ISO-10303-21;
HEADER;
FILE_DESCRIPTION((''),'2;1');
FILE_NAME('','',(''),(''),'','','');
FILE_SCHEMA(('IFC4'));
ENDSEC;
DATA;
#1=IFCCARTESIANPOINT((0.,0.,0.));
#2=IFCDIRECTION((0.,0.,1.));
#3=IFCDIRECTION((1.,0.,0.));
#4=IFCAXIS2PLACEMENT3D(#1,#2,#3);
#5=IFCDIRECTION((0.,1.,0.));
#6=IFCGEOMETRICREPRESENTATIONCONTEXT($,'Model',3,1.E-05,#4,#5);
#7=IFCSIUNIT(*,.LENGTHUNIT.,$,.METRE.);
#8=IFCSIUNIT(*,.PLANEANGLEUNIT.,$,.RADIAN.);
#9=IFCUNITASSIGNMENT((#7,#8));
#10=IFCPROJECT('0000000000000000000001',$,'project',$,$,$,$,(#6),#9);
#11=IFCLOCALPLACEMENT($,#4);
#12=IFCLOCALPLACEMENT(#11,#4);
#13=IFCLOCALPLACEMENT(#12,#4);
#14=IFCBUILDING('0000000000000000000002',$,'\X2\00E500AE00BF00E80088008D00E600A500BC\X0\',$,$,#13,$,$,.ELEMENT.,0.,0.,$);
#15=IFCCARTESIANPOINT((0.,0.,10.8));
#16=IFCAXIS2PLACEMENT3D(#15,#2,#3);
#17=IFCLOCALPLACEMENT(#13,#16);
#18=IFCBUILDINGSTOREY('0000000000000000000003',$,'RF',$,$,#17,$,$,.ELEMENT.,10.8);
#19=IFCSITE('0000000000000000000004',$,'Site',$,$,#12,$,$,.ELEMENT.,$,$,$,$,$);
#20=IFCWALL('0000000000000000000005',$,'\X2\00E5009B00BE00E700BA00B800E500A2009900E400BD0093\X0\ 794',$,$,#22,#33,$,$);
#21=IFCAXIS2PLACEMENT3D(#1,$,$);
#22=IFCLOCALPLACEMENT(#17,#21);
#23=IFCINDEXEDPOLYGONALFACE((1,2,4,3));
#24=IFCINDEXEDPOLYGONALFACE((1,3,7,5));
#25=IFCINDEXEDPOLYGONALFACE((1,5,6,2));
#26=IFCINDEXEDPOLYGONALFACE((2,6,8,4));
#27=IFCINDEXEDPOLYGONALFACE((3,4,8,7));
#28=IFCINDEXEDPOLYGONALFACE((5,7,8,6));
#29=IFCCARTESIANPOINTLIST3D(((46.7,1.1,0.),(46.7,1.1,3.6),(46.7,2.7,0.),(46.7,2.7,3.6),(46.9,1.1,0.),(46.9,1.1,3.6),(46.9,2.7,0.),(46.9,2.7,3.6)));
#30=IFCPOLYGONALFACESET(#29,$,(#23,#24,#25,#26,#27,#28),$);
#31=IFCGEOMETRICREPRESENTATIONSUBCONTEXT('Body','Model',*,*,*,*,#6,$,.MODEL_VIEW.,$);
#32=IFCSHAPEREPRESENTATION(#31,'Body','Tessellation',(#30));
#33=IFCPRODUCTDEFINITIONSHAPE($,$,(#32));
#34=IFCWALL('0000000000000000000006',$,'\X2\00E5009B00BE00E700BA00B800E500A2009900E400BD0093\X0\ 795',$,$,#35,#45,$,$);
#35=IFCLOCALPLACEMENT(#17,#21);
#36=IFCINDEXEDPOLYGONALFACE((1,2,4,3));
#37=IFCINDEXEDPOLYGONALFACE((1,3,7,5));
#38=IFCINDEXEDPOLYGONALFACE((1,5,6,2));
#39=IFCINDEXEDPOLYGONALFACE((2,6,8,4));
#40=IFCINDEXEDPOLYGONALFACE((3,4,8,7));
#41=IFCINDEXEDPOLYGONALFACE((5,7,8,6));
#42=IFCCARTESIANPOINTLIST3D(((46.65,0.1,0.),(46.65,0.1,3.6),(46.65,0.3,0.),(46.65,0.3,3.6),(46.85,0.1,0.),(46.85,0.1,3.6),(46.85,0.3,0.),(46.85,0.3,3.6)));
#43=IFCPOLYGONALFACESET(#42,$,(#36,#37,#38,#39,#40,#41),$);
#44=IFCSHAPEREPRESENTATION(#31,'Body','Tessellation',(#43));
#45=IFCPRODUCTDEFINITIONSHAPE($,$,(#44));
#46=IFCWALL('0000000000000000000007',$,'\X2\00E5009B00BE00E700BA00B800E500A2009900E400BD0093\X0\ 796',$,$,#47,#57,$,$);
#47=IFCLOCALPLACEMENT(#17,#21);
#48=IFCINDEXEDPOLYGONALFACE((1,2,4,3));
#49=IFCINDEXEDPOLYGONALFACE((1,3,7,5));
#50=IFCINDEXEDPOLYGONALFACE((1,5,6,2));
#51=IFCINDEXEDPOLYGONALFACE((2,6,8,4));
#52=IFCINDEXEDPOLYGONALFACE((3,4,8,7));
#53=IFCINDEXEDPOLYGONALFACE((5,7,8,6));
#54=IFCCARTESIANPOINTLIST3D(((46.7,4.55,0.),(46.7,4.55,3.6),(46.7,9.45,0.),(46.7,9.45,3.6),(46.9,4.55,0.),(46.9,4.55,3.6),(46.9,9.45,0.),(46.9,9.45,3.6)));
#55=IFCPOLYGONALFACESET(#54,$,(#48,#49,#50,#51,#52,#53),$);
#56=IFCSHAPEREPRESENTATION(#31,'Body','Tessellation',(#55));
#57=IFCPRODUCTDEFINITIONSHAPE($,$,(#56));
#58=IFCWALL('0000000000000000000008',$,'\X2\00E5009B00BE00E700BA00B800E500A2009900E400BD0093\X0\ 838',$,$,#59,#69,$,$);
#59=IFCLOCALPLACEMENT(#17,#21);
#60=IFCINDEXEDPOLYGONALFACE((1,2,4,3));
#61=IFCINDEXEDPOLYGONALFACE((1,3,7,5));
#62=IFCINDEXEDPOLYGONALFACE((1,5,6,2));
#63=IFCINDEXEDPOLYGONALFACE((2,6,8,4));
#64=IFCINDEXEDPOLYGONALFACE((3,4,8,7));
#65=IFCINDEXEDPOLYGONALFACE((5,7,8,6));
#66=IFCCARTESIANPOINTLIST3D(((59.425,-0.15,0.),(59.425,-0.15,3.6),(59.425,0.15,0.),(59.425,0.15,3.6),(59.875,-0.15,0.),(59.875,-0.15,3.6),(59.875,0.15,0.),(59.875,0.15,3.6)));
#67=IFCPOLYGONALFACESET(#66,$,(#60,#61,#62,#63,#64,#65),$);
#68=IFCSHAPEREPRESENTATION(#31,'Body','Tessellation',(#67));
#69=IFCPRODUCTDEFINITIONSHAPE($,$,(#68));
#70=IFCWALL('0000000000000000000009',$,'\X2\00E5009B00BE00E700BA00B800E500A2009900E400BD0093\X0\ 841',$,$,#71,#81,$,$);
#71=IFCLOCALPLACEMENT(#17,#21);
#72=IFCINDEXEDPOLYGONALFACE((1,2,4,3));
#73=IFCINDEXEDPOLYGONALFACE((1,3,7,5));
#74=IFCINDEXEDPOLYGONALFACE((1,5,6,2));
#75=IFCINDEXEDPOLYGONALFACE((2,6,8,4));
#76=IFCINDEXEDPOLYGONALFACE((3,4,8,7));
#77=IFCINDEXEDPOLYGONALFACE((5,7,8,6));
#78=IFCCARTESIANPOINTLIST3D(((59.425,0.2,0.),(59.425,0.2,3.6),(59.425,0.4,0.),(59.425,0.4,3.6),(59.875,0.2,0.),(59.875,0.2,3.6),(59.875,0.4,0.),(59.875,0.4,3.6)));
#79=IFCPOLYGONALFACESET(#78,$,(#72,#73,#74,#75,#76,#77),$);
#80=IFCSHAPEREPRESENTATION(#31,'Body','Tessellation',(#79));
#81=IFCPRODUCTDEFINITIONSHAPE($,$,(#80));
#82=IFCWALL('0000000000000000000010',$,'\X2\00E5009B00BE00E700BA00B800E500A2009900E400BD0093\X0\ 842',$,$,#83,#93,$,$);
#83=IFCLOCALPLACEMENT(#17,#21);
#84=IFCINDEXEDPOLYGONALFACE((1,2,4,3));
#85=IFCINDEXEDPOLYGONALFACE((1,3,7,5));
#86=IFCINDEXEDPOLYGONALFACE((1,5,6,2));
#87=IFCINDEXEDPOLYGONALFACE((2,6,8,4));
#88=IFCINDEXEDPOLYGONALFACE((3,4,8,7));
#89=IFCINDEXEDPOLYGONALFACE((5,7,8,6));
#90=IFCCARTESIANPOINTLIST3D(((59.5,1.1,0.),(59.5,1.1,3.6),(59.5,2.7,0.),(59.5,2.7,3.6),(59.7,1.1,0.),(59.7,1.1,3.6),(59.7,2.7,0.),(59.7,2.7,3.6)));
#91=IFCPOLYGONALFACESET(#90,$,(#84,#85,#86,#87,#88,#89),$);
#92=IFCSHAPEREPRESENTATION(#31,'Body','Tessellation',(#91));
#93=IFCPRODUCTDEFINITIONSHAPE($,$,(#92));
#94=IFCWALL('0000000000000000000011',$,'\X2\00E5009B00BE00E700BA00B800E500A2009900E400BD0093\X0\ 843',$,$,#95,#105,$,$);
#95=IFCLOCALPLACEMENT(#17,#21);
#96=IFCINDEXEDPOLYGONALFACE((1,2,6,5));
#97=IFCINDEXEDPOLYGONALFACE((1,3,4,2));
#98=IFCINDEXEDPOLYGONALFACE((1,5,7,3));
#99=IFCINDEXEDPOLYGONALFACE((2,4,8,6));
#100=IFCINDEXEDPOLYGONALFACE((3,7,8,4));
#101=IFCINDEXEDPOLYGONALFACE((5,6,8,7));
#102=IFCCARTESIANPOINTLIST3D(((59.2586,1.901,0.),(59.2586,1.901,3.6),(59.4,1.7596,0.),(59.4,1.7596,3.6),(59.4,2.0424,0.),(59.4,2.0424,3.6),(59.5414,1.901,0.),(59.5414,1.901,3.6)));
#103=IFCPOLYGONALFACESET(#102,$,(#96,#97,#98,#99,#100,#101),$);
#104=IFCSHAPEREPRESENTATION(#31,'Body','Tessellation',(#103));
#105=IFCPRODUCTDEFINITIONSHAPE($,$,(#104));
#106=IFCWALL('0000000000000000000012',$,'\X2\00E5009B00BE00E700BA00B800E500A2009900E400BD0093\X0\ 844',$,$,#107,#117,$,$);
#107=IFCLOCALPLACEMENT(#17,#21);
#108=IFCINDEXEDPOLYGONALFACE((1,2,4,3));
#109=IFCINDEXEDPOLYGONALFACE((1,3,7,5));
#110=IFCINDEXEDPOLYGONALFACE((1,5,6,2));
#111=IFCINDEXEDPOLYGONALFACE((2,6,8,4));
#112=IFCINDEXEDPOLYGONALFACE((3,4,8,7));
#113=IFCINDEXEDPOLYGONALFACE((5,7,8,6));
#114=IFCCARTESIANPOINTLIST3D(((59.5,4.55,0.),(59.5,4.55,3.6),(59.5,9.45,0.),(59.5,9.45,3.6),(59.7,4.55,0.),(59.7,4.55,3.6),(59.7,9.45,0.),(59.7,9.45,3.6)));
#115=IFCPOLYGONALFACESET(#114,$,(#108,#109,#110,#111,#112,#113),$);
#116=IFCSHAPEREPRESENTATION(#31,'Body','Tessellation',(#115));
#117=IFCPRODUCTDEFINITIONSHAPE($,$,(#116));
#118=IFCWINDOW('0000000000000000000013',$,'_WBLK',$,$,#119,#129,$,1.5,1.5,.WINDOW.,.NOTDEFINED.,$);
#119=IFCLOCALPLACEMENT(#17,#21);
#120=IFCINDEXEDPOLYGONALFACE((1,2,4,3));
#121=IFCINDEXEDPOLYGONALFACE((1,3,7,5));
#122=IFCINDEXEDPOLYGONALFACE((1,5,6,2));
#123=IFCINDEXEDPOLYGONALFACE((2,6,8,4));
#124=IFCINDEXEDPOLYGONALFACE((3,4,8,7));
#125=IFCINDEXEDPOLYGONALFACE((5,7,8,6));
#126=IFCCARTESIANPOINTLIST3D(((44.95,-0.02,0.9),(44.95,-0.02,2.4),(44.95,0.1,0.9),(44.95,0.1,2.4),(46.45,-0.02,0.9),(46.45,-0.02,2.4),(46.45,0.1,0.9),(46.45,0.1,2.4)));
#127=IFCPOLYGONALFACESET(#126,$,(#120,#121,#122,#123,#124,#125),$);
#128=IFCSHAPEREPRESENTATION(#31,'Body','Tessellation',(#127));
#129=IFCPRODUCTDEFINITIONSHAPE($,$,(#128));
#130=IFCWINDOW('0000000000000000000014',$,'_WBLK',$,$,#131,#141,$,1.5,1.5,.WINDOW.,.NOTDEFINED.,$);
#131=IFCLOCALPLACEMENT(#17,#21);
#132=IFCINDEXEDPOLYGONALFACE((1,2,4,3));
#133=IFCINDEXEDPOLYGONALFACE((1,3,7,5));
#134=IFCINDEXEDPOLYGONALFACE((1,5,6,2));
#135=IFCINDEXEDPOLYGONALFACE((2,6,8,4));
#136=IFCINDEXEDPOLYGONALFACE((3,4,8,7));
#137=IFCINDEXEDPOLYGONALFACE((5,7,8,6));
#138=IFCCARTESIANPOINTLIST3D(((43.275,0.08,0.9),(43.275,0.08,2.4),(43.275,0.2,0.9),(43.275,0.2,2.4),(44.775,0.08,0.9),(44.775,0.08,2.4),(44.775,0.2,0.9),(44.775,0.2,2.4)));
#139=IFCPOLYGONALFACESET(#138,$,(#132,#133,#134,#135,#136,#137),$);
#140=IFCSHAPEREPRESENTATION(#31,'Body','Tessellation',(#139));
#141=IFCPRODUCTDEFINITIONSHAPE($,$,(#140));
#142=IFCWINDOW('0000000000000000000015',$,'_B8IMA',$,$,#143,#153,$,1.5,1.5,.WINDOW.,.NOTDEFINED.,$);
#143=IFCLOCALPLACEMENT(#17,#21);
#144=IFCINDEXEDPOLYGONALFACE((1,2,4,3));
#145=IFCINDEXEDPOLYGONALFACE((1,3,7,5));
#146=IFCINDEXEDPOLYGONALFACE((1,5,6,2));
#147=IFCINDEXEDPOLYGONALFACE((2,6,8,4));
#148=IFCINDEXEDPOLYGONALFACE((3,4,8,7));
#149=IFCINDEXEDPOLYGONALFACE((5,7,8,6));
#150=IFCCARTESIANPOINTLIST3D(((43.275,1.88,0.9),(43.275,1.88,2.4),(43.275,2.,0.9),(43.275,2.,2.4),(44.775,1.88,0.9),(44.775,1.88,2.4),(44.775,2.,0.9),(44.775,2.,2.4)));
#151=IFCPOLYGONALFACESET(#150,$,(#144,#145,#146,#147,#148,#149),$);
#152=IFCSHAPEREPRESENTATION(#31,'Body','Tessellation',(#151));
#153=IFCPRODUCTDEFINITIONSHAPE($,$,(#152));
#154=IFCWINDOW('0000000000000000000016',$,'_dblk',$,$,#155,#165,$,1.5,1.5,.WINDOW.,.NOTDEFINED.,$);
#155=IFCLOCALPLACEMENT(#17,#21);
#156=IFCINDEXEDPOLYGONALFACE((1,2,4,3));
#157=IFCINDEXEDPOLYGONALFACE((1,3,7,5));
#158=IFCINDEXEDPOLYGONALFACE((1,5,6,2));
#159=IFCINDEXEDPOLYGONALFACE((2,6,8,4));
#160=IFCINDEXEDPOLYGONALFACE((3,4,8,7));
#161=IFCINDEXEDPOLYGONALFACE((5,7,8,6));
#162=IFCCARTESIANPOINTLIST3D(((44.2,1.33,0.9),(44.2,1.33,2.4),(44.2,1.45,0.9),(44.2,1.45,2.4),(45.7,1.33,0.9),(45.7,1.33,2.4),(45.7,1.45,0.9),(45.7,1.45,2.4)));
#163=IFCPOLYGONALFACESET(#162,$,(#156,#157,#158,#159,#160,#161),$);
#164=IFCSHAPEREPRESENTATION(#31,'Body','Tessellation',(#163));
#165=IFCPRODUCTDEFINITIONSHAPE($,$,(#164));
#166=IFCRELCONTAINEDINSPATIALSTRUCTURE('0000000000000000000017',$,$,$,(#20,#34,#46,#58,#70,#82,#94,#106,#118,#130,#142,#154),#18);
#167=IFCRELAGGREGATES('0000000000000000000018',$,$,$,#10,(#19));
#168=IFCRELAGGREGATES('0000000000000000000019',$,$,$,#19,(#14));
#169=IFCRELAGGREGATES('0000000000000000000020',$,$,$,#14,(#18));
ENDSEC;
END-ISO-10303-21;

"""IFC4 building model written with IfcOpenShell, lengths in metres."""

from ifc_helpers import new_model, si_unit, direction, frame, frame_2d, origin_with_axes, place, context, subcontext, project, spatial, rectangle, extrude, element, save


model = new_model("IFC4")

# Units and contexts
model_context = context("Model", 3, precision=1e-05, world=origin_with_axes(), true_north=direction((0.0, 1.0, 0.0)))
body_context = subcontext(model_context, "Body", "Model", "MODEL_VIEW")
ifc_project = project(units=[si_unit("LENGTHUNIT", "METRE"), si_unit("PLANEANGLEUNIT", "RADIAN")], contexts=[model_context])

# Site, building, storey
placement = place(None, origin_with_axes())
site_placement = place(placement, origin_with_axes())
site = spatial("IfcSite", under=ifc_project, at=site_placement, Name="Site", CompositionType="ELEMENT")
building_placement = place(site_placement, origin_with_axes())
building = spatial("IfcBuilding", under=site, at=building_placement, Name="å®¿è\u0088\u008dæ¥¼", CompositionType="ELEMENT", ElevationOfRefHeight=0.0, ElevationOfTerrain=0.0)
storey_placement = place(building_placement, frame((0.0, 0.0, 10.8), z_axis=(0.0, 0.0, 1.0), x_axis=(1.0, 0.0, 0.0)))
storey = spatial("IfcBuildingStorey", under=building, at=storey_placement, Name="RF", CompositionType="ELEMENT", Elevation=10.8)

# Walls
for number, where, z_axis, x_axis, name in (
    (1, (46.8, 1.9, 0.0), (0.0, 0.0, 1.0), (0.0, -1.0, 0.0), "å\u009b¾çº¸å¢\u0099ä½\u0093 794"),
):
    element("IfcWall", number, at=place(storey_placement, frame(where, z_axis=z_axis, x_axis=x_axis)), inside=storey, Name=name, context=body_context, shape_type="SweptSolid", body=[
        extrude(rectangle(XDim=1.6, YDim=0.2, at=frame_2d((0.0, 0.0), x_axis=(1.0, 0.0, 0.0))), frame((0.0, 0.0, 0.0), z_axis=(0.0, 0.0, 1.0)), (0.0, 0.0, 1.0), 3.6),
    ])
wall_1_placement = place(storey_placement, frame((46.75, 0.2, 0.0), z_axis=(0.0, 0.0, 1.0), x_axis=(0.0, -1.0, 0.0)))
element("IfcWall", 2, at=wall_1_placement, inside=storey, Name="å\u009b¾çº¸å¢\u0099ä½\u0093 795", context=body_context, shape_type="SweptSolid", body=[
    extrude(rectangle(XDim=0.2, YDim=0.2, at=frame_2d((0.0, 0.0), x_axis=(1.0, 0.0, 0.0))), frame((0.0, 0.0, 0.0), z_axis=(0.0, 0.0, 1.0)), (0.0, 0.0, 1.0), 3.6),
])
wall_2_placement = place(storey_placement, frame((46.8, 7.0, 0.0), z_axis=(0.0, 0.0, 1.0), x_axis=(0.0, -1.0, 0.0)))
element("IfcWall", 3, at=wall_2_placement, inside=storey, Name="å\u009b¾çº¸å¢\u0099ä½\u0093 796", context=body_context, shape_type="SweptSolid", body=[
    extrude(rectangle(XDim=4.9, YDim=0.2, at=frame_2d((0.0, 0.0), x_axis=(1.0, 0.0, 0.0))), frame((0.0, 0.0, 0.0), z_axis=(0.0, 0.0, 1.0)), (0.0, 0.0, 1.0), 3.6),
])
wall_3_placement = place(storey_placement, frame((59.65, 0.0, 0.0), z_axis=(0.0, 0.0, 1.0), x_axis=(1.0, 0.0, 0.0)))
element("IfcWall", 4, at=wall_3_placement, inside=storey, Name="å\u009b¾çº¸å¢\u0099ä½\u0093 838", context=body_context, shape_type="SweptSolid", body=[
    extrude(rectangle(XDim=0.45, YDim=0.3, at=frame_2d((0.0, 0.0), x_axis=(1.0, 0.0, 0.0))), frame((0.0, 0.0, 0.0), z_axis=(0.0, 0.0, 1.0)), (0.0, 0.0, 1.0), 3.6),
])
wall_4_placement = place(storey_placement, frame((59.65, 0.3, 0.0), z_axis=(0.0, 0.0, 1.0), x_axis=(1.0, 0.0, 0.0)))
element("IfcWall", 5, at=wall_4_placement, inside=storey, Name="å\u009b¾çº¸å¢\u0099ä½\u0093 841", context=body_context, shape_type="SweptSolid", body=[
    extrude(rectangle(XDim=0.45, YDim=0.2, at=frame_2d((0.0, 0.0), x_axis=(1.0, 0.0, 0.0))), frame((0.0, 0.0, 0.0), z_axis=(0.0, 0.0, 1.0)), (0.0, 0.0, 1.0), 3.6),
])
wall_5_placement = place(storey_placement, frame((59.6, 1.9, 0.0), z_axis=(0.0, 0.0, 1.0), x_axis=(0.0, -1.0, 0.0)))
element("IfcWall", 6, at=wall_5_placement, inside=storey, Name="å\u009b¾çº¸å¢\u0099ä½\u0093 842", context=body_context, shape_type="SweptSolid", body=[
    extrude(rectangle(XDim=1.6, YDim=0.2, at=frame_2d((0.0, 0.0), x_axis=(1.0, 0.0, 0.0))), frame((0.0, 0.0, 0.0), z_axis=(0.0, 0.0, 1.0)), (0.0, 0.0, 1.0), 3.6),
])
wall_6_placement = place(storey_placement, frame((59.4, 1.901, 0.0), z_axis=(0.0, 0.0, 1.0), x_axis=(0.707107, -0.707107, 0.0)))
element("IfcWall", 7, at=wall_6_placement, inside=storey, Name="å\u009b¾çº¸å¢\u0099ä½\u0093 843", context=body_context, shape_type="SweptSolid", body=[
    extrude(rectangle(XDim=0.2, YDim=0.2, at=frame_2d((0.0, 0.0), x_axis=(1.0, 0.0, 0.0))), frame((0.0, 0.0, 0.0), z_axis=(0.0, 0.0, 1.0)), (0.0, 0.0, 1.0), 3.6),
])
wall_7_placement = place(storey_placement, frame((59.6, 7.0, 0.0), z_axis=(0.0, 0.0, 1.0), x_axis=(0.0, -1.0, 0.0)))
element("IfcWall", 8, at=wall_7_placement, inside=storey, Name="å\u009b¾çº¸å¢\u0099ä½\u0093 844", context=body_context, shape_type="SweptSolid", body=[
    extrude(rectangle(XDim=4.9, YDim=0.2, at=frame_2d((0.0, 0.0), x_axis=(1.0, 0.0, 0.0))), frame((0.0, 0.0, 0.0), z_axis=(0.0, 0.0, 1.0)), (0.0, 0.0, 1.0), 3.6),
])

# Windows
for number, where, z_axis, x_axis, name in (
    (9, (45.7, 0.04, 0.9), (0.0, 0.0, 1.0), (1.0, 0.0, 0.0), "_WBLK"),
    (10, (44.025, 0.14, 0.9), (0.0, 0.0, 1.0), (1.0, 0.0, 0.0), "_WBLK"),
    (11, (44.025, 1.94, 0.9), (0.0, 0.0, 1.0), (1.0, 0.0, 0.0), "_B8IMA"),
    (12, (44.95, 1.39, 0.9), (0.0, 0.0, 1.0), (1.0, 0.0, 0.0), "_dblk"),
):
    element("IfcWindow", number, at=place(storey_placement, frame(where, z_axis=z_axis, x_axis=x_axis)), inside=storey, Name=name, OverallHeight=1.5, OverallWidth=1.5, PartitioningType="NOTDEFINED", PredefinedType="WINDOW", context=body_context, shape_type="SweptSolid", body=[
        extrude(rectangle(XDim=1.5, YDim=0.12, at=frame_2d((0.0, 0.0), x_axis=(1.0, 0.0, 0.0))), frame((0.0, 0.0, 0.0), z_axis=(0.0, 0.0, 1.0)), (0.0, 0.0, 1.0), 1.5),
    ])

save(model, "model.ifc")
